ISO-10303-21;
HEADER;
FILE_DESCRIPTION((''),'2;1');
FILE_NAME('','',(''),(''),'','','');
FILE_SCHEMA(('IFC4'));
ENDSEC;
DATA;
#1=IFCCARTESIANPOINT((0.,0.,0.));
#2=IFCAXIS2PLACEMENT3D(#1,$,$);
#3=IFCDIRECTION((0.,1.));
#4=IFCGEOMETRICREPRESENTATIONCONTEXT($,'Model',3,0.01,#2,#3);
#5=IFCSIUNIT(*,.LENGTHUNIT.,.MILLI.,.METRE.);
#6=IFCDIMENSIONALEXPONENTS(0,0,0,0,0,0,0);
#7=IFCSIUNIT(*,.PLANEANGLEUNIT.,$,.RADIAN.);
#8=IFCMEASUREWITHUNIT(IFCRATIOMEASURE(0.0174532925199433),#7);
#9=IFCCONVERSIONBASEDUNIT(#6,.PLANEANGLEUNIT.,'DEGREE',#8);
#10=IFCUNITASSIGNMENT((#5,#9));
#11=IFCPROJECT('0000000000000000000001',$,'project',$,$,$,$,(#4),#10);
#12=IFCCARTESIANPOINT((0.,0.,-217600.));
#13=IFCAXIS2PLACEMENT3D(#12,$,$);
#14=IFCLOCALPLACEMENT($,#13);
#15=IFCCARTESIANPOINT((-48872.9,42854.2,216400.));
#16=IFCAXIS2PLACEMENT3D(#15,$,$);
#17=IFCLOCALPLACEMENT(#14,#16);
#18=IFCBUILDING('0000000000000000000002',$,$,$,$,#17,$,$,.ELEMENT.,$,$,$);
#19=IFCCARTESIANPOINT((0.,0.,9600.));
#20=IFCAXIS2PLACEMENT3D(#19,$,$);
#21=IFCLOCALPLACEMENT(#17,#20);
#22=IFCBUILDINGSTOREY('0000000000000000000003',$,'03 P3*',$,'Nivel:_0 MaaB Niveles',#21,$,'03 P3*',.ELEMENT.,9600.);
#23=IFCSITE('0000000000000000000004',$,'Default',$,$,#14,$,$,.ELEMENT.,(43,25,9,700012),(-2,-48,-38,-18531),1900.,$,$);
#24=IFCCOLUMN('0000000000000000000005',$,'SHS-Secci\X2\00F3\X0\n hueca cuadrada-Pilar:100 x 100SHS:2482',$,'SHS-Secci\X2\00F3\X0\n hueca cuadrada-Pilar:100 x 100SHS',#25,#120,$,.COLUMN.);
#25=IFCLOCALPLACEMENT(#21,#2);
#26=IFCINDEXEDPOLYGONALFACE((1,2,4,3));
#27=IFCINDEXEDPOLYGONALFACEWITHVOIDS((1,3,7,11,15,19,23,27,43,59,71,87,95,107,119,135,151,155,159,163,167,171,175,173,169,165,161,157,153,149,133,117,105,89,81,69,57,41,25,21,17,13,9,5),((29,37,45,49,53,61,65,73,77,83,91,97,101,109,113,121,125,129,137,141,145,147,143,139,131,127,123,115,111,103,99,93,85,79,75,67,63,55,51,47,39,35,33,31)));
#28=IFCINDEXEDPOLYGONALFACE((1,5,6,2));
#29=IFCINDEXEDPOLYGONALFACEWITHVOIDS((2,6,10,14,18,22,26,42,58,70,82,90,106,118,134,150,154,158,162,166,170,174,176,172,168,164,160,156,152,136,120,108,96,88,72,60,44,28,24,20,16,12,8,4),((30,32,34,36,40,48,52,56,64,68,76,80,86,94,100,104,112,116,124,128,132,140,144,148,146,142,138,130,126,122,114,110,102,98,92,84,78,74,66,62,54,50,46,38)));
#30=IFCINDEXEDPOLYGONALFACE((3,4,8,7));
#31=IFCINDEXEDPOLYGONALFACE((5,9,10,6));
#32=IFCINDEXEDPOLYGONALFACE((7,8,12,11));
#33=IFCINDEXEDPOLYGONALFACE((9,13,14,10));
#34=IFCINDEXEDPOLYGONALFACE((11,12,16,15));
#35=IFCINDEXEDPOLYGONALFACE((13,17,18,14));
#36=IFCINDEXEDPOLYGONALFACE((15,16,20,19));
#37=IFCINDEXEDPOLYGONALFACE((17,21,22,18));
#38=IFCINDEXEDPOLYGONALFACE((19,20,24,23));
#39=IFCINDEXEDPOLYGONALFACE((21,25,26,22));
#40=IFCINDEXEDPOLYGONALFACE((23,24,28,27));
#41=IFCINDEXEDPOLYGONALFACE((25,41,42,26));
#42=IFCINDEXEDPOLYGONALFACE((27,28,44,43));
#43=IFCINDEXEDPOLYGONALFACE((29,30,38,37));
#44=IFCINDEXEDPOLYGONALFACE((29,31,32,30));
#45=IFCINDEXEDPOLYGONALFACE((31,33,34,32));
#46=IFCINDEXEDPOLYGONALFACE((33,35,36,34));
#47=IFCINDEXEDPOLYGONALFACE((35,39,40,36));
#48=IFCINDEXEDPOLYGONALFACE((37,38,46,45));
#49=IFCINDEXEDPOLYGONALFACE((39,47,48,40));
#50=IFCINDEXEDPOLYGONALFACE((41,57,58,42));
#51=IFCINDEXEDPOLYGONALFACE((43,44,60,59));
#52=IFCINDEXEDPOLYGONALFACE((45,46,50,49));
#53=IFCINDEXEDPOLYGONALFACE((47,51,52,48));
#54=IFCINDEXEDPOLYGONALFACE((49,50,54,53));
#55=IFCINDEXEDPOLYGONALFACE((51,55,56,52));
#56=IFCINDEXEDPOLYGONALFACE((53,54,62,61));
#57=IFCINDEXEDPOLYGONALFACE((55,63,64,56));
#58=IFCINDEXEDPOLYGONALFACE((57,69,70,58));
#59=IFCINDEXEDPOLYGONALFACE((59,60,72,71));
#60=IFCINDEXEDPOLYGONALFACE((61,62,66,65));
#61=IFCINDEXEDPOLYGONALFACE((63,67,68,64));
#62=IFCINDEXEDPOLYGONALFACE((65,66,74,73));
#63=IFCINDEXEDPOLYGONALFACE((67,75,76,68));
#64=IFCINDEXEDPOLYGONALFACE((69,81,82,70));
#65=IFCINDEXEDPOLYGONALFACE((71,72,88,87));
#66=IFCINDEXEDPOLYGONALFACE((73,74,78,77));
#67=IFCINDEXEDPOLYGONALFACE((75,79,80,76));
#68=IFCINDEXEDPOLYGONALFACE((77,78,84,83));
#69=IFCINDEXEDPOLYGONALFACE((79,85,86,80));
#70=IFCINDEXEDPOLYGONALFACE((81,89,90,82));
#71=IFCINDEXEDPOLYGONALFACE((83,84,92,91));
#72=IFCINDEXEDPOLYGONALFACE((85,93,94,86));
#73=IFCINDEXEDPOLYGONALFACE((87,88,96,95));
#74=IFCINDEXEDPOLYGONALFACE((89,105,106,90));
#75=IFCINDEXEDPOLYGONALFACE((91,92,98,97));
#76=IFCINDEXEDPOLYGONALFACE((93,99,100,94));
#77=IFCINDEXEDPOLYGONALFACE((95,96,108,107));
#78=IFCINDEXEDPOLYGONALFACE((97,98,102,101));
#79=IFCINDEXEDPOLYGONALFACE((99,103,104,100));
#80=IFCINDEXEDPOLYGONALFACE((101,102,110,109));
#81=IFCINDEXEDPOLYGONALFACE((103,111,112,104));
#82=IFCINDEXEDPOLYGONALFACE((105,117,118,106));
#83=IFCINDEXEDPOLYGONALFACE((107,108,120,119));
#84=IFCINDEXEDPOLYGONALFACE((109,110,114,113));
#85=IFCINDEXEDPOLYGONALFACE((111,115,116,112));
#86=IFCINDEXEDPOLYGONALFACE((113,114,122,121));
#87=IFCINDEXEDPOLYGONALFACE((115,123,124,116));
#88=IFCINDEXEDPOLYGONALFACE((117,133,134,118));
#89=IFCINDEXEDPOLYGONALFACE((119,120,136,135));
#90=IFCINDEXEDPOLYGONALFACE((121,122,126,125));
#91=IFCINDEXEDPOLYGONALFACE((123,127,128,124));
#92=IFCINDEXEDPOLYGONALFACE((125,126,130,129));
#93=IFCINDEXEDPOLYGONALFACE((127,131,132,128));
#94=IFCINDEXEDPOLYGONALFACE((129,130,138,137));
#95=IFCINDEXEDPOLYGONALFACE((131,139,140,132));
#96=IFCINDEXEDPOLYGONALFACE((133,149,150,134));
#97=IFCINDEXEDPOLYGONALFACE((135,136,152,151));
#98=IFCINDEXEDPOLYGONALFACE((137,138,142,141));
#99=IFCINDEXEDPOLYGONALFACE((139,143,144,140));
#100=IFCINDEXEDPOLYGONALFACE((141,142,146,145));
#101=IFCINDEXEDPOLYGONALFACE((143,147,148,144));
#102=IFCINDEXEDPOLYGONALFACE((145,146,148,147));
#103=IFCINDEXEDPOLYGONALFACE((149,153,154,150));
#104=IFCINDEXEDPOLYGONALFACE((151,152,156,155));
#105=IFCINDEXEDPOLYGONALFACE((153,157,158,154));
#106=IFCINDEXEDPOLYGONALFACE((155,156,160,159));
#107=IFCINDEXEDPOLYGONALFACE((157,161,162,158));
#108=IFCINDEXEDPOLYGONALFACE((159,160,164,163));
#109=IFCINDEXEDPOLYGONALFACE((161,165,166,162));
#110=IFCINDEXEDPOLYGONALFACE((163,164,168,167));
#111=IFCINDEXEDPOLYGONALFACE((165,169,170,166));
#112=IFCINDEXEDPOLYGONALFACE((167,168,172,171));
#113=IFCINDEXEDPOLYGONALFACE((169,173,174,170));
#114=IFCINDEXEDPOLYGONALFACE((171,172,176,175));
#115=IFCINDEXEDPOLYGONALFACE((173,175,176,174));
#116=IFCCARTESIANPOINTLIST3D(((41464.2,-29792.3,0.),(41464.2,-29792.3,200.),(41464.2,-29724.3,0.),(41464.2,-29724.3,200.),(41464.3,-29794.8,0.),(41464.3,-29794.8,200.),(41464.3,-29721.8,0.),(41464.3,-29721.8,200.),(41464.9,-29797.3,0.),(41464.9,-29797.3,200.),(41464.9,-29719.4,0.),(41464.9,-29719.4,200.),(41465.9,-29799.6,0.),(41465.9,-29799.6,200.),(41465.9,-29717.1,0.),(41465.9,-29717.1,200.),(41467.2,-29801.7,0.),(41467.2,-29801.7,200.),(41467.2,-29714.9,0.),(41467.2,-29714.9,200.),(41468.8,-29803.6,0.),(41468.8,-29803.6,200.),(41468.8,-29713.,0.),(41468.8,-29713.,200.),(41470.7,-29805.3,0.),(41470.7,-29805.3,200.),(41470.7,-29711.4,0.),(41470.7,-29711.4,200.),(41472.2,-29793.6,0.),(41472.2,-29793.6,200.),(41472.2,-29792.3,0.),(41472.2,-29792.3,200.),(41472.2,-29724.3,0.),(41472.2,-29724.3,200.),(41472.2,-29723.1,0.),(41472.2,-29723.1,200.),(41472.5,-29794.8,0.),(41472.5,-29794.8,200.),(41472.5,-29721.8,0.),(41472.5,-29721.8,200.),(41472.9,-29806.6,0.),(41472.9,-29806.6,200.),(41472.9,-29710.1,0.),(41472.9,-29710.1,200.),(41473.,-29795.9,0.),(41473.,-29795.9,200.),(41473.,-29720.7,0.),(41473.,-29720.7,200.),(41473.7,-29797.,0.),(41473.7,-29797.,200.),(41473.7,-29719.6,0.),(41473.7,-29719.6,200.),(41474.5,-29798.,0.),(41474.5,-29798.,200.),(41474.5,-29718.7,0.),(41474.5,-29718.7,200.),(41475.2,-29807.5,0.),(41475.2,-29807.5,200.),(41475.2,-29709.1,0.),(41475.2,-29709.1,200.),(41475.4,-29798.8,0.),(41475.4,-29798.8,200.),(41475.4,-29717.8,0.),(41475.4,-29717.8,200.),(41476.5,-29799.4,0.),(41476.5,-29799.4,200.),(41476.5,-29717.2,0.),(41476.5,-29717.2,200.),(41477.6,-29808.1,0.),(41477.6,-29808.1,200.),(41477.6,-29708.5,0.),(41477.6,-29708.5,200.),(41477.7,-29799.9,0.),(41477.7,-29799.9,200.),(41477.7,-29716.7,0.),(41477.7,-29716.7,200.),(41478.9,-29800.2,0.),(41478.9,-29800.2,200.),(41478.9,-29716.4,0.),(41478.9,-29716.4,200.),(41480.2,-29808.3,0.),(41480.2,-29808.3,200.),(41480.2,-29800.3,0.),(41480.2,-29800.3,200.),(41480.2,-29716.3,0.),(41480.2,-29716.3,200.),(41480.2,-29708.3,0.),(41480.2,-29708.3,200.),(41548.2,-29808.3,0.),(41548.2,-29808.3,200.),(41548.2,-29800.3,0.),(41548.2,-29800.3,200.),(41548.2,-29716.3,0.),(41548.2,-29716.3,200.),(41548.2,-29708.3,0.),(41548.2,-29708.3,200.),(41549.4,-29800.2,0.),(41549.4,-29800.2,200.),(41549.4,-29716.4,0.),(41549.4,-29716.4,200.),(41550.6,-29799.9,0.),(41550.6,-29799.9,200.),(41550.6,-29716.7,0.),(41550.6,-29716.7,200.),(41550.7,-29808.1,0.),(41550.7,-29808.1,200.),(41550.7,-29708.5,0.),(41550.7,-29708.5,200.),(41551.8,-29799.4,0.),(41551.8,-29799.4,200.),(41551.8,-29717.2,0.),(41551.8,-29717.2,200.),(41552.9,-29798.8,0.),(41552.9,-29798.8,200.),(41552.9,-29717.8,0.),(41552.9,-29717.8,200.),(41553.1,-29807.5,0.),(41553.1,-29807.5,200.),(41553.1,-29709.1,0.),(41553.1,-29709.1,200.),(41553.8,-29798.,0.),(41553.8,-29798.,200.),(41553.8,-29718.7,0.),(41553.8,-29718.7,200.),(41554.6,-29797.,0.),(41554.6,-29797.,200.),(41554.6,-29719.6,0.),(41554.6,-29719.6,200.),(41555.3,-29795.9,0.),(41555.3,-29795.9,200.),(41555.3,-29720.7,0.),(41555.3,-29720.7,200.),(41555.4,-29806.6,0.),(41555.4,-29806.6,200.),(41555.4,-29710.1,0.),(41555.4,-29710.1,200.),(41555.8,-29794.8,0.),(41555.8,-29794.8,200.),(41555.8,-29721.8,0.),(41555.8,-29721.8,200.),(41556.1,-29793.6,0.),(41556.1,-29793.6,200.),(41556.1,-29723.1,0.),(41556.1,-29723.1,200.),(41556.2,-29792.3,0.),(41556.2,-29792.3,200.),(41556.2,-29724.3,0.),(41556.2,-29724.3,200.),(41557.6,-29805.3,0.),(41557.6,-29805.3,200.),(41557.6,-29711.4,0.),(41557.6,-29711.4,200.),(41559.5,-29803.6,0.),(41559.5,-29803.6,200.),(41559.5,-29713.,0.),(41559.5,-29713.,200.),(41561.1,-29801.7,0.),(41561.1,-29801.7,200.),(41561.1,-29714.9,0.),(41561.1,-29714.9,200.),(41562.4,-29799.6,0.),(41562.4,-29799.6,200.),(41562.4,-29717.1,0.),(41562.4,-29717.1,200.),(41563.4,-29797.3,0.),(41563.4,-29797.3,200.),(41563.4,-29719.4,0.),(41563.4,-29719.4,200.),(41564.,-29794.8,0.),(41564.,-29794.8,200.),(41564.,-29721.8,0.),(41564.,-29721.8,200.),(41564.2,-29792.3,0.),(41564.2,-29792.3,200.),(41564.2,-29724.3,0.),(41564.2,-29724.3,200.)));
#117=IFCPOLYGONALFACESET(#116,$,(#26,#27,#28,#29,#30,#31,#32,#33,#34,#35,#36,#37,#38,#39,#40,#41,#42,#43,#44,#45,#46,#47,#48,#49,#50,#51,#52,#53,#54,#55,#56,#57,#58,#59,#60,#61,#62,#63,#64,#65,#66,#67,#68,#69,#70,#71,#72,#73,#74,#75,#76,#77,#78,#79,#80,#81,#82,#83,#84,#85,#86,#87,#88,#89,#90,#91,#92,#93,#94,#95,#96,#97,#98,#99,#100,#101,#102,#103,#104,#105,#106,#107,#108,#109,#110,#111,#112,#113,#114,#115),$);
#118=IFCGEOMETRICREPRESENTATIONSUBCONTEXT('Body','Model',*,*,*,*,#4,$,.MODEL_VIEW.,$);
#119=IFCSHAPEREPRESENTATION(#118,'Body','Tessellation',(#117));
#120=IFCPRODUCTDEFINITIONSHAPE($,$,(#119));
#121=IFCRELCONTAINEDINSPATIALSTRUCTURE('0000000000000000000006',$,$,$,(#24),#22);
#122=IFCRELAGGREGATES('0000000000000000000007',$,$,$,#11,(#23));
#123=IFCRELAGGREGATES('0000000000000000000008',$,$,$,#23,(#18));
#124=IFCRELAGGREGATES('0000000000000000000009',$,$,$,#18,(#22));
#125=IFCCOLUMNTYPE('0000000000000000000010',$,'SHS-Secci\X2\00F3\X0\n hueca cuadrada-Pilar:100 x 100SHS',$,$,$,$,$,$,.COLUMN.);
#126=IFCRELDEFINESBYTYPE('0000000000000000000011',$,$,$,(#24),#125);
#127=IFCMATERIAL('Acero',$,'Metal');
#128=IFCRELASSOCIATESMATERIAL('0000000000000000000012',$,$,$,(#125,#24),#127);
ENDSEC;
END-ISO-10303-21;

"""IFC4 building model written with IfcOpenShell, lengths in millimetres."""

from ifc_helpers import new_model, entity, si_unit, converted_unit, direction, frame, origin, place, context, subcontext, project, spatial, indexed_curve, outline, extrude, source, transform, mapped, material, type_object, type_shapes, element, save


model = new_model("IFC4")

# Units and contexts
model_context = context("Model", 3, precision=0.01, world=origin(), true_north=direction((0.0, 1.0)))
body_context = subcontext(model_context, "Body", "Model", "MODEL_VIEW")
ifc_project = project(units=[si_unit("LENGTHUNIT", "METRE", prefix="MILLI"), converted_unit("PLANEANGLEUNIT", "DEGREE", entity("IfcRatioMeasure", 0.0174532925199433), si_unit("PLANEANGLEUNIT", "RADIAN"), dimensions=[0, 0, 0, 0, 0, 0, 0])], contexts=[model_context])

# Site, building, storey
site_placement = place(None, frame((0.0, 0.0, -217600.0)))
site = spatial("IfcSite", under=ifc_project, at=site_placement, Name="Default", CompositionType="ELEMENT", RefLatitude=(43, 25, 9, 700012), RefLongitude=(-2, -48, -38, -18531), RefElevation=1900.0)
building_placement = place(site_placement, frame((-48872.9, 42854.2, 216400.0)))
building = spatial("IfcBuilding", under=site, at=building_placement, CompositionType="ELEMENT")
storey_placement = place(building_placement, frame((0.0, 0.0, 9600.0)))
storey = spatial("IfcBuildingStorey", under=building, at=storey_placement, Name="03 P3*", ObjectType="Nivel:_0 MaaB Niveles", LongName="03 P3*", CompositionType="ELEMENT", Elevation=9600.0)

# Column
ifc_material_1 = material(Name="Acero", Category="Metal")
column_type_1 = type_object("IfcColumnType", Name="SHS-Sección hueca cuadrada-Pilar:100 x 100SHS", PredefinedType="COLUMN", material=ifc_material_1)
shared_shape_1 = source(origin(), body_context, "Body", "SweptSolid", [
    extrude(outline(indexed_curve([(-34.0, -50.0), (34.0, -50.0), (36.5, -49.8), (38.9, -49.2), (41.3, -48.3), (43.4, -46.9), (45.3, -45.3), (46.9, -43.4), (48.3, -41.3), (49.2, -38.9), (49.8, -36.5), (50.0, -34.0), (50.0, 34.0), (49.8, 36.5), (49.2, 38.9), (48.3, 41.3), (46.9, 43.4), (45.3, 45.3), (43.4, 46.9), (41.3, 48.3), (38.9, 49.2), (36.5, 49.8), (34.0, 50.0), (-34.0, 50.0), (-36.5, 49.8), (-38.9, 49.2), (-41.3, 48.3), (-43.4, 46.9), (-45.3, 45.3), (-46.9, 43.4), (-48.3, 41.3), (-49.2, 38.9), (-49.8, 36.5), (-50.0, 34.0), (-50.0, -34.0), (-49.8, -36.5), (-49.2, -38.9), (-48.3, -41.3), (-46.9, -43.4), (-45.3, -45.3), (-43.4, -46.9), (-41.3, -48.3), (-38.9, -49.2), (-36.5, -49.8), (-34.0, -50.0)], self_intersect=False), holes=[indexed_curve([(-42.0, 34.0), (-41.9, 35.3), (-41.6, 36.5), (-41.1, 37.6), (-40.5, 38.7), (-39.7, 39.7), (-38.7, 40.5), (-37.6, 41.1), (-36.5, 41.6), (-35.3, 41.9), (-34.0, 42.0), (34.0, 42.0), (35.3, 41.9), (36.5, 41.6), (37.6, 41.1), (38.7, 40.5), (39.7, 39.7), (40.5, 38.7), (41.1, 37.6), (41.6, 36.5), (41.9, 35.3), (42.0, 34.0), (42.0, -34.0), (41.9, -35.3), (41.6, -36.5), (41.1, -37.6), (40.5, -38.7), (39.7, -39.7), (38.7, -40.5), (37.6, -41.1), (36.5, -41.6), (35.3, -41.9), (34.0, -42.0), (-34.0, -42.0), (-35.3, -41.9), (-36.5, -41.6), (-37.6, -41.1), (-38.7, -40.5), (-39.7, -39.7), (-40.5, -38.7), (-41.1, -37.6), (-41.6, -36.5), (-41.9, -35.3), (-42.0, -34.0), (-42.0, 34.0)], self_intersect=False)]), frame((0.0, 0.0, 9600.0), z_axis=(0.0, 0.0, 1.0), x_axis=(0.0, 1.0, 0.0)), (0.0, 0.0, 1.0), 200.0),
])
type_shapes(column_type_1, [shared_shape_1])
column_1_placement = place(storey_placement, frame((41514.2, -29758.3, -9600.0), z_axis=(0.0, 0.0, 1.0), x_axis=(0.0, -1.0, 0.0)))
element("IfcColumn", 1, at=column_1_placement, inside=storey, type_object=column_type_1, material=ifc_material_1, Name="SHS-Sección hueca cuadrada-Pilar:100 x 100SHS:2482", ObjectType="SHS-Sección hueca cuadrada-Pilar:100 x 100SHS", PredefinedType="COLUMN", context=body_context, shape_type="MappedRepresentation", body=[
    mapped(shared_shape_1, transform((0.0, 0.0, 0.0), scale=1.0)),
])

save(model, "model.ifc")
